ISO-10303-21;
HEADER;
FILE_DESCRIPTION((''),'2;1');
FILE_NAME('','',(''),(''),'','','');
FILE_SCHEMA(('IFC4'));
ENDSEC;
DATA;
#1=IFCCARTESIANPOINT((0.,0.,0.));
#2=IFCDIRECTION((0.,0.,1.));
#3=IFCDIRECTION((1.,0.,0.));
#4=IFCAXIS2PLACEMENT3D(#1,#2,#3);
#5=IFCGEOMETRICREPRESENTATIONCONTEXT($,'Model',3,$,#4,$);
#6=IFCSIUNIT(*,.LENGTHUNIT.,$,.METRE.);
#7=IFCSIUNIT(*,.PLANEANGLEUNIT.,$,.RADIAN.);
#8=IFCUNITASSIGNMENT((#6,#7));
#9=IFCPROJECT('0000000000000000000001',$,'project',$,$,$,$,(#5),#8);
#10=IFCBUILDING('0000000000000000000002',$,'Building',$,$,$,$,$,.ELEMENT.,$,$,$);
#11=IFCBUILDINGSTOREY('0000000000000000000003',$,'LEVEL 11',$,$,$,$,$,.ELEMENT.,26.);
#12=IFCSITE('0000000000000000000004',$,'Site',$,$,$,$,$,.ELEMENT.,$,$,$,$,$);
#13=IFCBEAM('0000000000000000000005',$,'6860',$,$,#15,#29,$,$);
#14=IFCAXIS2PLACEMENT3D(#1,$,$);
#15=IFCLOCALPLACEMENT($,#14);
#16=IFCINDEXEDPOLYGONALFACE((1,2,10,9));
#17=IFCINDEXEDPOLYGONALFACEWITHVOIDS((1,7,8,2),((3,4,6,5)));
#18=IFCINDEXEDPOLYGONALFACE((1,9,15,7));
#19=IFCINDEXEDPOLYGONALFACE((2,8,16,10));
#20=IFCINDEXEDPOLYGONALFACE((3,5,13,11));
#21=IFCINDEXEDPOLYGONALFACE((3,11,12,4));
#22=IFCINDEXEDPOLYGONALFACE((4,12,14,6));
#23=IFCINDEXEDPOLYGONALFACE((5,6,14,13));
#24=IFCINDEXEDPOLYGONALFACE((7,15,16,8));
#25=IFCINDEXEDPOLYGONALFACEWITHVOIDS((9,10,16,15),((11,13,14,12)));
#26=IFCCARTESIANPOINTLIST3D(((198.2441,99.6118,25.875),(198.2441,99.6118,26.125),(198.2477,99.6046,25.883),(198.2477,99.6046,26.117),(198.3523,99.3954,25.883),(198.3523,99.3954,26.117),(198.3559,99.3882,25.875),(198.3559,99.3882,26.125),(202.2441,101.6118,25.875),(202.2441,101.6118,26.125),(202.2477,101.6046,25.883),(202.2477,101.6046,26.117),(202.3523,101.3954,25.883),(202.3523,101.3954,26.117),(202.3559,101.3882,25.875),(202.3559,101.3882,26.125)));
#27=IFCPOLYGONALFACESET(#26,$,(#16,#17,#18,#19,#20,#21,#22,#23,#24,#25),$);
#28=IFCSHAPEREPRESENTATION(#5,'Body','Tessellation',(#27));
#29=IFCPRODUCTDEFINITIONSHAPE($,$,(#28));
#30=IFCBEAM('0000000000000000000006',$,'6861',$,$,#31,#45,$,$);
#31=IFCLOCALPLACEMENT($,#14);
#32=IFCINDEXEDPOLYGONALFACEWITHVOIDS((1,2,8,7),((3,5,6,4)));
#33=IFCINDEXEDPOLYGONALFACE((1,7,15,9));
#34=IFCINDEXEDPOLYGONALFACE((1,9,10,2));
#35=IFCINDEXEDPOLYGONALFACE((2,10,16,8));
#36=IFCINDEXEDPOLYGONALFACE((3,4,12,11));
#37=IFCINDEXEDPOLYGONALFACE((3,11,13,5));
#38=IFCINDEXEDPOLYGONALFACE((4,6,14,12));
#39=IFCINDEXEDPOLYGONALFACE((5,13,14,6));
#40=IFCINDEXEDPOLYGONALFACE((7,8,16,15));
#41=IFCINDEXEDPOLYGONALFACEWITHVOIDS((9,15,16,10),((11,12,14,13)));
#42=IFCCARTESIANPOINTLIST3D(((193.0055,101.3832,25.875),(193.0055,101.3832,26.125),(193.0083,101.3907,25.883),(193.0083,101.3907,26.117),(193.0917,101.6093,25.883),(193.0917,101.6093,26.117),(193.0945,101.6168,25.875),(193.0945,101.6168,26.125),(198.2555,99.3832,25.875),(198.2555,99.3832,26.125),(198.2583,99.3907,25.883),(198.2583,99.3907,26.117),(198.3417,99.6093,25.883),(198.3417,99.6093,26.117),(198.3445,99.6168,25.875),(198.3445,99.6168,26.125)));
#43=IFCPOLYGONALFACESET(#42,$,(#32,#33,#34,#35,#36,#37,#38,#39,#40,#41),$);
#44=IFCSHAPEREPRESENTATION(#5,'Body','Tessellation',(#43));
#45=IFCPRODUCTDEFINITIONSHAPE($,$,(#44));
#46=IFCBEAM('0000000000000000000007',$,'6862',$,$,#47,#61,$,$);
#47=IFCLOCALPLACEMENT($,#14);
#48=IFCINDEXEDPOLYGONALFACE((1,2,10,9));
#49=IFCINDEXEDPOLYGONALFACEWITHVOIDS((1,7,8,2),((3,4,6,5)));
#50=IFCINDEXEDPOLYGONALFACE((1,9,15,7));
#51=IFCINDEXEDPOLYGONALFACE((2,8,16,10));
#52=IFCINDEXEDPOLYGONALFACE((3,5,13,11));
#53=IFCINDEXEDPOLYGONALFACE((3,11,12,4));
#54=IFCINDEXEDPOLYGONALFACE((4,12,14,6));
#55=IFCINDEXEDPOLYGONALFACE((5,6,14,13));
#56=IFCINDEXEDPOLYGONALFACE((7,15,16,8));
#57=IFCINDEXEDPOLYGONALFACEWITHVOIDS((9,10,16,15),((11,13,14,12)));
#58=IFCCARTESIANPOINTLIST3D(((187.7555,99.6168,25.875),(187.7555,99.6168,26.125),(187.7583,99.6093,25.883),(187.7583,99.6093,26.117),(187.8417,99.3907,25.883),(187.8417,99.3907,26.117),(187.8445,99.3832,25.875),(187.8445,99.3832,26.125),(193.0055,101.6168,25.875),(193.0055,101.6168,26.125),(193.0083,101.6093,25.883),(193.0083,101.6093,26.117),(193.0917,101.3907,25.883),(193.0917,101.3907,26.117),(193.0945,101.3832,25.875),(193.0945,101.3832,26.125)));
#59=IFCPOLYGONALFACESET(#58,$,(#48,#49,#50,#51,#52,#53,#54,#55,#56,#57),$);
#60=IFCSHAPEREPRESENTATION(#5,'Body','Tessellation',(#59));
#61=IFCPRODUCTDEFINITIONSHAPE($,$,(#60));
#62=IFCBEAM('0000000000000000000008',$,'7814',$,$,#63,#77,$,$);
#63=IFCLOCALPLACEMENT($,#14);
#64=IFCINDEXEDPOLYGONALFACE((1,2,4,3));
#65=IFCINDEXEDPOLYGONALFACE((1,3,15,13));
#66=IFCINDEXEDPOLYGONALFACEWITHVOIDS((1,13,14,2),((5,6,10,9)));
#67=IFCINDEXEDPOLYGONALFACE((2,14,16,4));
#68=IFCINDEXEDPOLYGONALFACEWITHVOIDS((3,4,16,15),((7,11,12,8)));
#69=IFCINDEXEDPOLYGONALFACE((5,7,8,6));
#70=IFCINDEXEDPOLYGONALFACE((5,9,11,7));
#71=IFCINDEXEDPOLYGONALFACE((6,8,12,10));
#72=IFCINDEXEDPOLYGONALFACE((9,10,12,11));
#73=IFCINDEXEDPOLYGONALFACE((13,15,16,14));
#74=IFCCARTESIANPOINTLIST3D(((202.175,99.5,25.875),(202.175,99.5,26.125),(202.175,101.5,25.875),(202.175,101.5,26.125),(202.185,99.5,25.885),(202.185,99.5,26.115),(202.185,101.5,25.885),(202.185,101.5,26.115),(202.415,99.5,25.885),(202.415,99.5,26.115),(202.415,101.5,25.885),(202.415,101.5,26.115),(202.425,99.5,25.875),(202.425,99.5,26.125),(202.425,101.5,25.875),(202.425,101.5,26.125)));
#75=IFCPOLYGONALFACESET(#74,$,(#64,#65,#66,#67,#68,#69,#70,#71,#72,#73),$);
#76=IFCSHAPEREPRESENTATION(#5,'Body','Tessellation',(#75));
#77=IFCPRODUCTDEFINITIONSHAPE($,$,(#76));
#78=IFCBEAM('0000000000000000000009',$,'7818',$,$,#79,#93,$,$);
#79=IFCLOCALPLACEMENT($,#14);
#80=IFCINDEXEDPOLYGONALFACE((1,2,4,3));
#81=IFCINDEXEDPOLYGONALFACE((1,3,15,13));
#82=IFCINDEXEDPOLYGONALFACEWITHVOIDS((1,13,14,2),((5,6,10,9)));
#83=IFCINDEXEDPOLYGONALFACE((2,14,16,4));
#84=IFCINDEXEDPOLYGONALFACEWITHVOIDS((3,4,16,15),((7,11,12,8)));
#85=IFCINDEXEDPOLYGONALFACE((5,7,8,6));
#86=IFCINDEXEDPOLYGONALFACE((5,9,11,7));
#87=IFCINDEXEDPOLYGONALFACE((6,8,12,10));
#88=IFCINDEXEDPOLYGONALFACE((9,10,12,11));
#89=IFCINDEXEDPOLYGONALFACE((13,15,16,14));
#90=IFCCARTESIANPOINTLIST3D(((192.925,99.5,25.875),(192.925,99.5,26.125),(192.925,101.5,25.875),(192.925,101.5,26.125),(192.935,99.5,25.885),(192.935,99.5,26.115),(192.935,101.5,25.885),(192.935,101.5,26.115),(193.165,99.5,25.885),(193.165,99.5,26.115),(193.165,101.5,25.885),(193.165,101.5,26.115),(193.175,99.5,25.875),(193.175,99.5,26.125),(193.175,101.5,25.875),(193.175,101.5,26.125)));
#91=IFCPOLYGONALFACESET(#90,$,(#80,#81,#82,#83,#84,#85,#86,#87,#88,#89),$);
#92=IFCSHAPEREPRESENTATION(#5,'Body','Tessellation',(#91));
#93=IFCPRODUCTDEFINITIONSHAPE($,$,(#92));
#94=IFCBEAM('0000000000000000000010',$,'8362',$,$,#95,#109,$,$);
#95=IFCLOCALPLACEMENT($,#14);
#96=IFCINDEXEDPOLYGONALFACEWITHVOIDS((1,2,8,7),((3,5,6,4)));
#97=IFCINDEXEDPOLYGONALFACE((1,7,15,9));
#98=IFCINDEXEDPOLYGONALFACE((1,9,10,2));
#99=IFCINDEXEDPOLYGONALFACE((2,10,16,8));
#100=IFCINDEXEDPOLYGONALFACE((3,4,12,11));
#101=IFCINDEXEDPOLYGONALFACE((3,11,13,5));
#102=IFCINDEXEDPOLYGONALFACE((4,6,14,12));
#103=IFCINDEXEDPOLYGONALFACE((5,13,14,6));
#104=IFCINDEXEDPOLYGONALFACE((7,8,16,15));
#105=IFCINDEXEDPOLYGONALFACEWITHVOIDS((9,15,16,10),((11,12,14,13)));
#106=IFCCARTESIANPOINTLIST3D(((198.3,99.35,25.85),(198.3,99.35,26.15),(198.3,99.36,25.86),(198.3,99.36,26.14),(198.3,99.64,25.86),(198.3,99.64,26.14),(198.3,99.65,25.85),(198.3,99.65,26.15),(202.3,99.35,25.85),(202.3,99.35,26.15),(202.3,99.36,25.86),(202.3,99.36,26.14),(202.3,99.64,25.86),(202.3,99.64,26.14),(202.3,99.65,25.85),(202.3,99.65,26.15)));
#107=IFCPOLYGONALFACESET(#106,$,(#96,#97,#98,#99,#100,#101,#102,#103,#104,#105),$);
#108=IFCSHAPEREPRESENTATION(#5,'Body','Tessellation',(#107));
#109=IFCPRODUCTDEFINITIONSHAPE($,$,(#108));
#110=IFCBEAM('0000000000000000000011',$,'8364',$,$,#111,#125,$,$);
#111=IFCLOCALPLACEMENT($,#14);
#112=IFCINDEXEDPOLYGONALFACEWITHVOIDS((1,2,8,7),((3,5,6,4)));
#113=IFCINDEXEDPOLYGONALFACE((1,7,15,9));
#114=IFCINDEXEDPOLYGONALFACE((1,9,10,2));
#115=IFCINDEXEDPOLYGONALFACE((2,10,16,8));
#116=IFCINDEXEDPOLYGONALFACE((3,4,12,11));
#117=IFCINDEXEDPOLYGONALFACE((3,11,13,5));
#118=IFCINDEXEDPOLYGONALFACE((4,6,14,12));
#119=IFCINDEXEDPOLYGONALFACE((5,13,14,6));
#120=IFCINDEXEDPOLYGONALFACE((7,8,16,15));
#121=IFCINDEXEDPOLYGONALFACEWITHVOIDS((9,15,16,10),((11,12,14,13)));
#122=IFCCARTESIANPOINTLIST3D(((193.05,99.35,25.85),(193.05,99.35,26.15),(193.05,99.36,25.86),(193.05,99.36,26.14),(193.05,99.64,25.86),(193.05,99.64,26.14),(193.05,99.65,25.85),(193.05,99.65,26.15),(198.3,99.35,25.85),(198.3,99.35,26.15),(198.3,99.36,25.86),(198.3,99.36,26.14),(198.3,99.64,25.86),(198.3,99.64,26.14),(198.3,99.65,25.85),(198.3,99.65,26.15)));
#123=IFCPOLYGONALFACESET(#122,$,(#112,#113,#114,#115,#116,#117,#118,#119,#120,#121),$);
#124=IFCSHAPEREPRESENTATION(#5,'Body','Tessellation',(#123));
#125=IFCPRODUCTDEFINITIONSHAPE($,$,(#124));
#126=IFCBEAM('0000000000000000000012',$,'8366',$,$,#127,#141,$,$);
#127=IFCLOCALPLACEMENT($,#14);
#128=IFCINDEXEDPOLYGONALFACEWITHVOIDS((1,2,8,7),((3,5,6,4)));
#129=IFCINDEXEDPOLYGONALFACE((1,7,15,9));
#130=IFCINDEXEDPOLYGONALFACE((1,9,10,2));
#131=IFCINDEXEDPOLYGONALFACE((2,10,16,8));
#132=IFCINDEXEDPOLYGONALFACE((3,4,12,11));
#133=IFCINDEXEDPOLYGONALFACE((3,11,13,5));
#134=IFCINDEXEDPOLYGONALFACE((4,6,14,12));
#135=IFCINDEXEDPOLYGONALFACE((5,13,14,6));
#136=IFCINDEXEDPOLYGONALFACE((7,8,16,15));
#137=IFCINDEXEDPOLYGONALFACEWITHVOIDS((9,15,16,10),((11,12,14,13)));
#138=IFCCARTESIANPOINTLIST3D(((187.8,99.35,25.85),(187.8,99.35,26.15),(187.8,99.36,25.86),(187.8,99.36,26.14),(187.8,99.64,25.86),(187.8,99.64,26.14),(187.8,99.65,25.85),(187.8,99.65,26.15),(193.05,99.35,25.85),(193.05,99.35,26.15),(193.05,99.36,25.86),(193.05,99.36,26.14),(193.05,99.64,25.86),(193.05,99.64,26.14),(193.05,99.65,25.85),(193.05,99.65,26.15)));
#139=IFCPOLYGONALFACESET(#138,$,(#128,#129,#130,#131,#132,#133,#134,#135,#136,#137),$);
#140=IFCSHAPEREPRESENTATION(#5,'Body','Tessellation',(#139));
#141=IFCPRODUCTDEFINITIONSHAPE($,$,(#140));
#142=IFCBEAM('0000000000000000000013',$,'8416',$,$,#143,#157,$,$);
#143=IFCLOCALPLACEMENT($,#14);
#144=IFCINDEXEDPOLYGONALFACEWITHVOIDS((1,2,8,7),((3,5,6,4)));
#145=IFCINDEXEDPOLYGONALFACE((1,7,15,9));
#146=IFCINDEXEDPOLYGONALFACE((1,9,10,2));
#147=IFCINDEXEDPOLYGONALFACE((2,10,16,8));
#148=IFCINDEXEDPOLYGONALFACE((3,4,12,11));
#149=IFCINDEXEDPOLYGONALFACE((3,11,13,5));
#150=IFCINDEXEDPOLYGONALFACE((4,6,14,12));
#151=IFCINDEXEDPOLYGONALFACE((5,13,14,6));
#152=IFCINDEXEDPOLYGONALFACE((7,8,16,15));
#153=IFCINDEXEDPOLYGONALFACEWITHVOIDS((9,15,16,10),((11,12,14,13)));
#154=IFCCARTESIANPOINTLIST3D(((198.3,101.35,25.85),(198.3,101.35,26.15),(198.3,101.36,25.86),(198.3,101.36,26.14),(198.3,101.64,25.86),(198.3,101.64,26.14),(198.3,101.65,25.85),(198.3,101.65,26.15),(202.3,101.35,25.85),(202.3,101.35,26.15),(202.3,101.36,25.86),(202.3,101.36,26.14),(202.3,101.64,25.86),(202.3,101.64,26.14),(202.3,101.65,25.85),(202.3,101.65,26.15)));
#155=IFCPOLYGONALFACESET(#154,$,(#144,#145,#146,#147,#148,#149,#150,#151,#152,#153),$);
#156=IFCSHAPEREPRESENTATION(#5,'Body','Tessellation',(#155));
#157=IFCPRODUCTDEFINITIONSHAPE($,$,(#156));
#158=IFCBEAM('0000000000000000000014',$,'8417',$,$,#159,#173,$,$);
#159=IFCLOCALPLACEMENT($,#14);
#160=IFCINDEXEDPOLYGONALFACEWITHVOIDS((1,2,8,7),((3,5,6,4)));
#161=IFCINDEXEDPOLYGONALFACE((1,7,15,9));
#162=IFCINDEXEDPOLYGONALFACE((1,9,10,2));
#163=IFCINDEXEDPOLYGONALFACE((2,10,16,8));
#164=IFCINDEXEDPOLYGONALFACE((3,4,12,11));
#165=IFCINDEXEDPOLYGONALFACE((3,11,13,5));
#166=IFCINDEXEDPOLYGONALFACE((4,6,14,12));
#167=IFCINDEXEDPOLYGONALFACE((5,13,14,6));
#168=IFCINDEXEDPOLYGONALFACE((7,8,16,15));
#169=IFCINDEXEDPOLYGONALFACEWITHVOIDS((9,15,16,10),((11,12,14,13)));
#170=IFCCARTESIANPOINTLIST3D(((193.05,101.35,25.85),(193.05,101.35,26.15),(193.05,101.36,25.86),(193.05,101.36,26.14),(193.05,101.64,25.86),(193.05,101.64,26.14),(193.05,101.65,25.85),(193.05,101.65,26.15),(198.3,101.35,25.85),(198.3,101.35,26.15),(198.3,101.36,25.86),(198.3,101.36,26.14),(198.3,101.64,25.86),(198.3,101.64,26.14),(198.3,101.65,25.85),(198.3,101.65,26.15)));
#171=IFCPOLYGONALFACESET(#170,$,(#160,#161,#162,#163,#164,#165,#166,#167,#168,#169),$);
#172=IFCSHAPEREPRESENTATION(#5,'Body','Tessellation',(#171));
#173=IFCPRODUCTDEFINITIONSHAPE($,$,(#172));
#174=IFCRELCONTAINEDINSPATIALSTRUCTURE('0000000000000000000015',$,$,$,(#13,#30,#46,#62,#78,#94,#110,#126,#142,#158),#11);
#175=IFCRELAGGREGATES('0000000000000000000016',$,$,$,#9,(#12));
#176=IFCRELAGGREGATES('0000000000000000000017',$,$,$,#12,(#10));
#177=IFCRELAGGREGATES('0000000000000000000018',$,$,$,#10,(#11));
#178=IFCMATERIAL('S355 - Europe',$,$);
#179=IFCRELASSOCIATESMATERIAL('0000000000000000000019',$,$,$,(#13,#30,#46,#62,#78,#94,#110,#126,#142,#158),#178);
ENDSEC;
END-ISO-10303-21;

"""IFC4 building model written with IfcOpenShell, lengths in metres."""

from ifc_helpers import new_model, si_unit, frame, origin_with_axes, origin_2d_with_axis, place, context, project, spatial, hollow_rectangle, extrude, material, material_profile, profile_set, profile_usage, element, save


model = new_model("IFC4")

# Units and contexts
model_context = context("Model", 3, world=origin_with_axes())
ifc_project = project(units=[si_unit("LENGTHUNIT", "METRE"), si_unit("PLANEANGLEUNIT", "RADIAN")], contexts=[model_context])

# Site, building, storey
site = spatial("IfcSite", under=ifc_project, Name="Site", CompositionType="ELEMENT")
building = spatial("IfcBuilding", under=site, Name="Building", CompositionType="ELEMENT")
storey = spatial("IfcBuildingStorey", under=building, Name="LEVEL 11", CompositionType="ELEMENT", Elevation=26.0)

# Shared definitions
ifc_material = material(Name="S355 - Europe")

# Beams
ifc_material_profile_1 = material_profile(ifc_material, hollow_rectangle(XDim=0.25, YDim=0.25, WallThickness=0.008, at=origin_2d_with_axis()))
ifc_profile_set_1 = profile_set([ifc_material_profile_1])
ifc_profile_usage_1 = profile_usage(ifc_profile_set_1, cardinal=10)
beam_1_placement = place(None, frame((202.3, 101.5, 26.0), z_axis=(-0.894427, -0.447214, 0.0), x_axis=(0.447214, -0.894427, 0.0)))
element("IfcBeam", 1, at=beam_1_placement, inside=storey, material=ifc_profile_usage_1, Name="6860", context=model_context, shape_type="SweptSolid", body=[
    extrude(hollow_rectangle(XDim=0.25, YDim=0.25, WallThickness=0.008, at=origin_2d_with_axis()), origin_with_axes(), (0.0, 0.0, 1.0), 4.4721),
])
ifc_material_profile_2 = material_profile(ifc_material, hollow_rectangle(XDim=0.25, YDim=0.25, WallThickness=0.008, at=origin_2d_with_axis()))
ifc_profile_set_2 = profile_set([ifc_material_profile_2])
ifc_profile_usage_2 = profile_usage(ifc_profile_set_2, cardinal=10)
beam_2_placement = place(None, frame((198.3, 99.5, 26.0), z_axis=(-0.934488, 0.355995, 0.0), x_axis=(-0.355995, -0.934488, 0.0)))
element("IfcBeam", 2, at=beam_2_placement, inside=storey, material=ifc_profile_usage_2, Name="6861", context=model_context, shape_type="SweptSolid", body=[
    extrude(hollow_rectangle(XDim=0.25, YDim=0.25, WallThickness=0.008, at=origin_2d_with_axis()), origin_with_axes(), (0.0, 0.0, 1.0), 5.6181),
])
ifc_material_profile_3 = material_profile(ifc_material, hollow_rectangle(XDim=0.25, YDim=0.25, WallThickness=0.008, at=origin_2d_with_axis()))
ifc_profile_set_3 = profile_set([ifc_material_profile_3])
ifc_profile_usage_3 = profile_usage(ifc_profile_set_3, cardinal=10)
beam_3_placement = place(None, frame((193.05, 101.5, 26.0), z_axis=(-0.934488, -0.355995, 0.0), x_axis=(0.355995, -0.934488, 0.0)))
element("IfcBeam", 3, at=beam_3_placement, inside=storey, material=ifc_profile_usage_3, Name="6862", context=model_context, shape_type="SweptSolid", body=[
    extrude(hollow_rectangle(XDim=0.25, YDim=0.25, WallThickness=0.008, at=origin_2d_with_axis()), origin_with_axes(), (0.0, 0.0, 1.0), 5.6181),
])
ifc_material_profile_4 = material_profile(ifc_material, hollow_rectangle(XDim=0.25, YDim=0.25, WallThickness=0.01, at=origin_2d_with_axis()))
ifc_profile_set_4 = profile_set([ifc_material_profile_4])
ifc_profile_usage_4 = profile_usage(ifc_profile_set_4, cardinal=10)
beam_4_placement = place(None, frame((202.3, 101.5, 26.0), z_axis=(0.0, -1.0, 0.0), x_axis=(1.0, 0.0, 0.0)))
element("IfcBeam", 4, at=beam_4_placement, inside=storey, material=ifc_profile_usage_4, Name="7814", context=model_context, shape_type="SweptSolid", body=[
    extrude(hollow_rectangle(XDim=0.25, YDim=0.25, WallThickness=0.01, at=origin_2d_with_axis()), origin_with_axes(), (0.0, 0.0, 1.0), 2.0),
])
ifc_material_profile_5 = material_profile(ifc_material, hollow_rectangle(XDim=0.25, YDim=0.25, WallThickness=0.01, at=origin_2d_with_axis()))
ifc_profile_set_5 = profile_set([ifc_material_profile_5])
ifc_profile_usage_5 = profile_usage(ifc_profile_set_5, cardinal=10)
beam_5_placement = place(None, frame((193.05, 101.5, 26.0), z_axis=(0.0, -1.0, 0.0), x_axis=(1.0, 0.0, 0.0)))
element("IfcBeam", 5, at=beam_5_placement, inside=storey, material=ifc_profile_usage_5, Name="7818", context=model_context, shape_type="SweptSolid", body=[
    extrude(hollow_rectangle(XDim=0.25, YDim=0.25, WallThickness=0.01, at=origin_2d_with_axis()), origin_with_axes(), (0.0, 0.0, 1.0), 2.0),
])
ifc_material_profile_6 = material_profile(ifc_material, hollow_rectangle(XDim=0.3, YDim=0.3, WallThickness=0.01, at=origin_2d_with_axis()))
ifc_profile_set_6 = profile_set([ifc_material_profile_6])
ifc_profile_usage_6 = profile_usage(ifc_profile_set_6, cardinal=10)
beam_6_placement = place(None, frame((202.3, 99.5, 26.0), z_axis=(-1.0, 0.0, 0.0), x_axis=(0.0, -1.0, 0.0)))
element("IfcBeam", 6, at=beam_6_placement, inside=storey, material=ifc_profile_usage_6, Name="8362", context=model_context, shape_type="SweptSolid", body=[
    extrude(hollow_rectangle(XDim=0.3, YDim=0.3, WallThickness=0.01, at=origin_2d_with_axis()), origin_with_axes(), (0.0, 0.0, 1.0), 4.0),
])
ifc_material_profile_7 = material_profile(ifc_material, hollow_rectangle(XDim=0.3, YDim=0.3, WallThickness=0.01, at=origin_2d_with_axis()))
ifc_profile_set_7 = profile_set([ifc_material_profile_7])
ifc_profile_usage_7 = profile_usage(ifc_profile_set_7, cardinal=10)
beam_7_placement = place(None, frame((198.3, 99.5, 26.0), z_axis=(-1.0, 0.0, 0.0), x_axis=(0.0, -1.0, 0.0)))
element("IfcBeam", 7, at=beam_7_placement, inside=storey, material=ifc_profile_usage_7, Name="8364", context=model_context, shape_type="SweptSolid", body=[
    extrude(hollow_rectangle(XDim=0.3, YDim=0.3, WallThickness=0.01, at=origin_2d_with_axis()), origin_with_axes(), (0.0, 0.0, 1.0), 5.25),
])
ifc_material_profile_8 = material_profile(ifc_material, hollow_rectangle(XDim=0.3, YDim=0.3, WallThickness=0.01, at=origin_2d_with_axis()))
ifc_profile_set_8 = profile_set([ifc_material_profile_8])
ifc_profile_usage_8 = profile_usage(ifc_profile_set_8, cardinal=10)
beam_8_placement = place(None, frame((193.05, 99.5, 26.0), z_axis=(-1.0, 0.0, 0.0), x_axis=(0.0, -1.0, 0.0)))
element("IfcBeam", 8, at=beam_8_placement, inside=storey, material=ifc_profile_usage_8, Name="8366", context=model_context, shape_type="SweptSolid", body=[
    extrude(hollow_rectangle(XDim=0.3, YDim=0.3, WallThickness=0.01, at=origin_2d_with_axis()), origin_with_axes(), (0.0, 0.0, 1.0), 5.25),
])
ifc_material_profile_9 = material_profile(ifc_material, hollow_rectangle(XDim=0.3, YDim=0.3, WallThickness=0.01, at=origin_2d_with_axis()))
ifc_profile_set_9 = profile_set([ifc_material_profile_9])
ifc_profile_usage_9 = profile_usage(ifc_profile_set_9, cardinal=10)
beam_9_placement = place(None, frame((202.3, 101.5, 26.0), z_axis=(-1.0, 0.0, 0.0), x_axis=(0.0, -1.0, 0.0)))
element("IfcBeam", 9, at=beam_9_placement, inside=storey, material=ifc_profile_usage_9, Name="8416", context=model_context, shape_type="SweptSolid", body=[
    extrude(hollow_rectangle(XDim=0.3, YDim=0.3, WallThickness=0.01, at=origin_2d_with_axis()), origin_with_axes(), (0.0, 0.0, 1.0), 4.0),
])
ifc_material_profile_10 = material_profile(ifc_material, hollow_rectangle(XDim=0.3, YDim=0.3, WallThickness=0.01, at=origin_2d_with_axis()))
ifc_profile_set_10 = profile_set([ifc_material_profile_10])
ifc_profile_usage_10 = profile_usage(ifc_profile_set_10, cardinal=10)
beam_10_placement = place(None, frame((198.3, 101.5, 26.0), z_axis=(-1.0, 0.0, 0.0), x_axis=(0.0, -1.0, 0.0)))
element("IfcBeam", 10, at=beam_10_placement, inside=storey, material=ifc_profile_usage_10, Name="8417", context=model_context, shape_type="SweptSolid", body=[
    extrude(hollow_rectangle(XDim=0.3, YDim=0.3, WallThickness=0.01, at=origin_2d_with_axis()), origin_with_axes(), (0.0, 0.0, 1.0), 5.25),
])

save(model, "model.ifc")
